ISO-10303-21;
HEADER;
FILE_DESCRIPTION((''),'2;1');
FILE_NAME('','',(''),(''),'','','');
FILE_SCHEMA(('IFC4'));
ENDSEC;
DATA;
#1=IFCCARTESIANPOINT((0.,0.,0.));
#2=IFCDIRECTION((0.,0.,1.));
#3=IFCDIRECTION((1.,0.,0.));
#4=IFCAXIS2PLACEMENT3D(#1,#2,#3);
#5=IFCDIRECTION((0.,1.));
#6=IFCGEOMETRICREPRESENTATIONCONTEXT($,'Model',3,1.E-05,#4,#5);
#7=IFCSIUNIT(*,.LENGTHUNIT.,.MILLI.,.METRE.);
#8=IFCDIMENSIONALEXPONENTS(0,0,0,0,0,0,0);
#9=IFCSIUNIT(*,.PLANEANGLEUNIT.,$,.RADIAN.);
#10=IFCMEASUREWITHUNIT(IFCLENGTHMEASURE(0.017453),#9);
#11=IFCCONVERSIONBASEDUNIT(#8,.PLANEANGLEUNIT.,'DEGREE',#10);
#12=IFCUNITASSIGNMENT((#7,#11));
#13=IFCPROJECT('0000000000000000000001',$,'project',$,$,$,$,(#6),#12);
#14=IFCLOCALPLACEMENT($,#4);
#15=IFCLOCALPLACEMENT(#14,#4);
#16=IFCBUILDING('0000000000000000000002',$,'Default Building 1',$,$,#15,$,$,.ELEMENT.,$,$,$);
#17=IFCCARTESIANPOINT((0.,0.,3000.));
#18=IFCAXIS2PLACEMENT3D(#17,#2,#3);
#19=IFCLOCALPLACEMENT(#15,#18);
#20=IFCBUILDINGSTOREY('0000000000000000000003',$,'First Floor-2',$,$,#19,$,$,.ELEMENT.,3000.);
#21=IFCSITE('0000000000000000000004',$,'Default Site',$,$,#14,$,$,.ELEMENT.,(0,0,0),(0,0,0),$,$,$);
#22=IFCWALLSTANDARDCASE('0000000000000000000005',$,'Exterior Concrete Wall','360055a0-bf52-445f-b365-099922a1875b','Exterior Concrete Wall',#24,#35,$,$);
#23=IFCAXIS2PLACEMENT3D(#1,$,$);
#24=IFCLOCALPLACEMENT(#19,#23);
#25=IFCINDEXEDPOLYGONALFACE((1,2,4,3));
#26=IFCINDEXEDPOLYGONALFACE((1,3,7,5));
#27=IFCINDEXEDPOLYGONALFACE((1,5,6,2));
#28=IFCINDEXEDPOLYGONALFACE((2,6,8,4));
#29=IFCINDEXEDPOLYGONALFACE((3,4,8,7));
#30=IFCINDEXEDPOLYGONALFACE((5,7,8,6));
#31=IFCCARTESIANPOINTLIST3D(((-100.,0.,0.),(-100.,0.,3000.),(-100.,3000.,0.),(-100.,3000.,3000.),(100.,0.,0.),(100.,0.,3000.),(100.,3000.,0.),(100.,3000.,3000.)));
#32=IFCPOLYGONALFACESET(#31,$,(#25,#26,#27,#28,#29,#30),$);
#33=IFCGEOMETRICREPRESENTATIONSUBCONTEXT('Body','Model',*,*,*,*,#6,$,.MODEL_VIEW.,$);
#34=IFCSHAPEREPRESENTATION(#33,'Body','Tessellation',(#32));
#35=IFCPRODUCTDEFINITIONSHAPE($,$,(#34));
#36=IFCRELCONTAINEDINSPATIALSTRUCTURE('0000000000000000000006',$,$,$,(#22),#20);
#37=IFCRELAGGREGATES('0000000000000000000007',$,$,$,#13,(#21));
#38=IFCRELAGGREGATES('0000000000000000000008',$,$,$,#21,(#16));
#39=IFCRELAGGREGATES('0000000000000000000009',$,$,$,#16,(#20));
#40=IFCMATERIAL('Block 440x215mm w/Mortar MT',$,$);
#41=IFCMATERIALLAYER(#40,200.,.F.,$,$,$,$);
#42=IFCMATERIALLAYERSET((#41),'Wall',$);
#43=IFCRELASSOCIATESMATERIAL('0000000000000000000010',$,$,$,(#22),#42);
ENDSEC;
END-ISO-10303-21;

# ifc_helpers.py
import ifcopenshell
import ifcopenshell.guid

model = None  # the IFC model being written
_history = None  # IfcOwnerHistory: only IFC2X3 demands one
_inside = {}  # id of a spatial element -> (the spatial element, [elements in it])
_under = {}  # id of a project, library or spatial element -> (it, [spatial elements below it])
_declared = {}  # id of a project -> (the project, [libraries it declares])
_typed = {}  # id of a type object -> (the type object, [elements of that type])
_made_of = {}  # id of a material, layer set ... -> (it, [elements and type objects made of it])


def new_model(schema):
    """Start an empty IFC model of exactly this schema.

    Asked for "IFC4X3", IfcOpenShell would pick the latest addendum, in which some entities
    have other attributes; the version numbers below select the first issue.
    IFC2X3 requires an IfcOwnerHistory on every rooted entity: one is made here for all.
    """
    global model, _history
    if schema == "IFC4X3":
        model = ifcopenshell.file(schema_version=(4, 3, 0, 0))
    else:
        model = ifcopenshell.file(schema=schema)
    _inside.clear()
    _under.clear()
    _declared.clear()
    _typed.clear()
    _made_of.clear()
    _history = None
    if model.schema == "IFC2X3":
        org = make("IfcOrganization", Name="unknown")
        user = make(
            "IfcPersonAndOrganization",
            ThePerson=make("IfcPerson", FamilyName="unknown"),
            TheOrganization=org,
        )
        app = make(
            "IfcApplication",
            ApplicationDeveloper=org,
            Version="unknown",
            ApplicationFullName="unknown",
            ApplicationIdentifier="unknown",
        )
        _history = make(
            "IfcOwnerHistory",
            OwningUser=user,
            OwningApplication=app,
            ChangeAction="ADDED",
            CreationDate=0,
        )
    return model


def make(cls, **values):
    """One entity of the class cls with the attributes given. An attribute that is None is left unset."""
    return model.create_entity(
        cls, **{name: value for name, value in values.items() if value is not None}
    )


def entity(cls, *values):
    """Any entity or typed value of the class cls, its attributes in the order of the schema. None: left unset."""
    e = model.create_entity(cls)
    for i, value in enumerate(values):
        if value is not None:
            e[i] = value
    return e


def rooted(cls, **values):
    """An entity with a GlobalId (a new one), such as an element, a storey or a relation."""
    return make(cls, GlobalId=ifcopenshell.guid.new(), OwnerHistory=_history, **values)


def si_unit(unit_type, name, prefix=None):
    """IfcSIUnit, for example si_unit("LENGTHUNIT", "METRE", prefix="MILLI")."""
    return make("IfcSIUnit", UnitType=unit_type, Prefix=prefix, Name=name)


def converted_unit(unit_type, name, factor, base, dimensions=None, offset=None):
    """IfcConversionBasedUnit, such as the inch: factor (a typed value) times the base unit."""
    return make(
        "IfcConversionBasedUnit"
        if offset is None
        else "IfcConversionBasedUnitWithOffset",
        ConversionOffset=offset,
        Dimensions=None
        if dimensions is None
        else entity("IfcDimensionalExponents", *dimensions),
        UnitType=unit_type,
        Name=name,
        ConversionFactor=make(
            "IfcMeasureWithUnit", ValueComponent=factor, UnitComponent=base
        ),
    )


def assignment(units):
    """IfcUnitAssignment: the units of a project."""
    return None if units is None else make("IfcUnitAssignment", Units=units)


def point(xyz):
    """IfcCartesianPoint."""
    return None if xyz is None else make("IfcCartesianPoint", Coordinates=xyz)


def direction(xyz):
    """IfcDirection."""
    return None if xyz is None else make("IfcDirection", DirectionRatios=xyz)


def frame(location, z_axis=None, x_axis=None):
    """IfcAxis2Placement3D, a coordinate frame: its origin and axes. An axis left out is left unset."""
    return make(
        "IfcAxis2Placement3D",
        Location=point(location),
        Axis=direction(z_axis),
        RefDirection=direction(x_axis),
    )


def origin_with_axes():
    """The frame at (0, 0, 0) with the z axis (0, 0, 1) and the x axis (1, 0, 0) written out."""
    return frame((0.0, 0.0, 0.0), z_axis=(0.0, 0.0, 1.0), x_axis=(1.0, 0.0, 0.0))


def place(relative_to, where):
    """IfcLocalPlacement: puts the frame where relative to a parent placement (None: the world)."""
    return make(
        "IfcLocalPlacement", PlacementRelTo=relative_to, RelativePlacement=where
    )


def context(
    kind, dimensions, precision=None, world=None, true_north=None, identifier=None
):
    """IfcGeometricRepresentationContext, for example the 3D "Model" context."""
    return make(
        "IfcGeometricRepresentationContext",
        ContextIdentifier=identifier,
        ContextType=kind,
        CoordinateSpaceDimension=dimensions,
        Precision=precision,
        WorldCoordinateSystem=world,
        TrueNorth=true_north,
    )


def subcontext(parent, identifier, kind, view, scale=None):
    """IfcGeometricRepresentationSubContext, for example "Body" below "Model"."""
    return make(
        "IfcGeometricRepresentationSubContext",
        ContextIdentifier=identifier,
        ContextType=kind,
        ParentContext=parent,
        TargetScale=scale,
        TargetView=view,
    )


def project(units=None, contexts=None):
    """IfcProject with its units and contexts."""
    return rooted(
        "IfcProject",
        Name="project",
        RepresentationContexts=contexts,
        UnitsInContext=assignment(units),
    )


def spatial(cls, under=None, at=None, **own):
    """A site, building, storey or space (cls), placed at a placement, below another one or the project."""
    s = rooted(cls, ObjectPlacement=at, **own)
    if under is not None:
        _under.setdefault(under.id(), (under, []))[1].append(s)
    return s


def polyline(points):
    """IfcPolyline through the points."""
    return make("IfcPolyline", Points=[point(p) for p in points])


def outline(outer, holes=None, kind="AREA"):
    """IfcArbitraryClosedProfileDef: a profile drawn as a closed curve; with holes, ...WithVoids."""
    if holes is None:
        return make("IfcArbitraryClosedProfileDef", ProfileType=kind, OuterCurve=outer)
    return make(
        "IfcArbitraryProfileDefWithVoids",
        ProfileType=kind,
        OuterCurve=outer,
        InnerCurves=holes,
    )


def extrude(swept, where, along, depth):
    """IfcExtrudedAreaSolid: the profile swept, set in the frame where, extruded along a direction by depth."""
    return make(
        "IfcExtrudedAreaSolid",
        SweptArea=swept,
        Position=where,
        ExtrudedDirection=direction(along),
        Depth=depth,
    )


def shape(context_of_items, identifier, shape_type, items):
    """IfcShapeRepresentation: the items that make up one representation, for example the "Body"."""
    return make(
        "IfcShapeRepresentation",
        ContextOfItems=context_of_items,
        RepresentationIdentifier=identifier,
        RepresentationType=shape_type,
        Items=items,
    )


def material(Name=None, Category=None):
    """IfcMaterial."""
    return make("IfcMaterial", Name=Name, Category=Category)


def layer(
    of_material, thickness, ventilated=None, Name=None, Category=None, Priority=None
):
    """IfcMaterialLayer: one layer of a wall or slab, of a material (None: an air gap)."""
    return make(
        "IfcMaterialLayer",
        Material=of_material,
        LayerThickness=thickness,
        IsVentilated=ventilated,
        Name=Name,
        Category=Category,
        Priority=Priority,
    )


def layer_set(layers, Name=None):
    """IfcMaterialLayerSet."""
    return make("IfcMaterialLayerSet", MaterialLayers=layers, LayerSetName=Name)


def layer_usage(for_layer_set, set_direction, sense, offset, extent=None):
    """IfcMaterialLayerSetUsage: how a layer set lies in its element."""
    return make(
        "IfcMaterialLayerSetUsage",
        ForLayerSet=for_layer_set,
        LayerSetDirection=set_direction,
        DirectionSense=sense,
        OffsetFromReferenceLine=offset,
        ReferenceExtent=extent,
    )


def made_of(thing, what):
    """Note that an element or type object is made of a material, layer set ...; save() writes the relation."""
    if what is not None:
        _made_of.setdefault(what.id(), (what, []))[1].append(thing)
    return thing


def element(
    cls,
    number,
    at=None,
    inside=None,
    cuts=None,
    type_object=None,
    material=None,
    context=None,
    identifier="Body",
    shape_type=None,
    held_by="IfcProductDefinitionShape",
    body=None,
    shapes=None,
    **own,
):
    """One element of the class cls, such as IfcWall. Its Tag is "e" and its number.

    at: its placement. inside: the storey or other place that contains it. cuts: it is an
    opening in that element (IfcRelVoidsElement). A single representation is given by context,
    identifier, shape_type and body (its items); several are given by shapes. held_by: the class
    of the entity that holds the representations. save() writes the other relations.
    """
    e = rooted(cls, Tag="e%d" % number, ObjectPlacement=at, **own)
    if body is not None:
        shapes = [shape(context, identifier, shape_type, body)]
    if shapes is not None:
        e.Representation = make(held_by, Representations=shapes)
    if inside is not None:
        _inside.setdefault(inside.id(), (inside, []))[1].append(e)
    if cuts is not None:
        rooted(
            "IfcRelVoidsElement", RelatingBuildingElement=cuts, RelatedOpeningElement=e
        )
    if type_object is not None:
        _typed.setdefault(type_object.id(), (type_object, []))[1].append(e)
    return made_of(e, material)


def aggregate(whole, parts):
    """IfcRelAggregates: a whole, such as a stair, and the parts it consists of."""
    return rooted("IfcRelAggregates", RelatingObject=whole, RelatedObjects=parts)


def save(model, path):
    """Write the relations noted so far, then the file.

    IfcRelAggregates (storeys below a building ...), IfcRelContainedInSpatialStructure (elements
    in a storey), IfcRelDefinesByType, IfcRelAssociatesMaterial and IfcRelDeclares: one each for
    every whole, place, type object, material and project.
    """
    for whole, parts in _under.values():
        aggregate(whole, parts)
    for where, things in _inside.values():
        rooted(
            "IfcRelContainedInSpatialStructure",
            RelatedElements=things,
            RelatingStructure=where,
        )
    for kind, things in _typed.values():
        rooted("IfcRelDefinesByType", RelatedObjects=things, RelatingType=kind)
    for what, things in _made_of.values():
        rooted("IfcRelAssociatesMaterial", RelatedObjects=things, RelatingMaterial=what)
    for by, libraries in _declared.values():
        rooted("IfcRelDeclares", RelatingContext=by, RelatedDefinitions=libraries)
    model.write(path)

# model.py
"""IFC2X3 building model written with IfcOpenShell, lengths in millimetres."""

from ifc_helpers import new_model, entity, si_unit, converted_unit, direction, frame, origin_with_axes, place, context, subcontext, project, spatial, polyline, outline, extrude, material, layer, layer_set, layer_usage, element, save


model = new_model("IFC2X3")

# Units and contexts
model_context = context("Model", 3, precision=1e-05, world=origin_with_axes(), true_north=direction((0.0, 1.0)))
body_context = subcontext(model_context, "Body", "Model", "MODEL_VIEW")
ifc_project = project(units=[si_unit("LENGTHUNIT", "METRE", prefix="MILLI"), converted_unit("PLANEANGLEUNIT", "DEGREE", entity("IfcLengthMeasure", 0.017453), si_unit("PLANEANGLEUNIT", "RADIAN"), dimensions=[0, 0, 0, 0, 0, 0, 0])], contexts=[model_context])

# Site, building, storey
site_placement = place(None, origin_with_axes())
site = spatial("IfcSite", under=ifc_project, at=site_placement, Name="Default Site", CompositionType="ELEMENT", RefLatitude=(0, 0, 0), RefLongitude=(0, 0, 0))
building_placement = place(site_placement, origin_with_axes())
building = spatial("IfcBuilding", under=site, at=building_placement, Name="Default Building 1", CompositionType="ELEMENT")
storey_placement = place(building_placement, frame((0.0, 0.0, 3000.0), z_axis=(0.0, 0.0, 1.0), x_axis=(1.0, 0.0, 0.0)))
storey = spatial("IfcBuildingStorey", under=building, at=storey_placement, Name="First Floor-2", CompositionType="ELEMENT", Elevation=3000.0)

# Wall
ifc_material_1 = material(Name="Block 440x215mm w/Mortar MT")
ifc_layer_1 = layer(ifc_material_1, 200.0, ventilated=False)
ifc_layer_set_1 = layer_set([ifc_layer_1], Name="Wall")
ifc_layer_usage_1 = layer_usage(ifc_layer_set_1, "AXIS2", "POSITIVE", -100.0)
wall_placement = place(storey_placement, frame((0.0, 3000.0, 0.0), z_axis=(0.0, 0.0, 1.0), x_axis=(0.0, -1.0, 0.0)))
element("IfcWallStandardCase", 1, at=wall_placement, inside=storey, material=ifc_layer_usage_1, Name="Exterior Concrete Wall", Description="360055a0-bf52-445f-b365-099922a1875b", ObjectType="Exterior Concrete Wall", context=body_context, shape_type="SweptSolid", body=[
    extrude(outline(polyline([(0.0, -100.0), (0.0, 100.0), (3000.0, 100.0), (3000.0, -100.0), (0.0, -100.0)])), origin_with_axes(), (0.0, 0.0, 1.0), 3000.0),
])

save(model, "model.ifc")
